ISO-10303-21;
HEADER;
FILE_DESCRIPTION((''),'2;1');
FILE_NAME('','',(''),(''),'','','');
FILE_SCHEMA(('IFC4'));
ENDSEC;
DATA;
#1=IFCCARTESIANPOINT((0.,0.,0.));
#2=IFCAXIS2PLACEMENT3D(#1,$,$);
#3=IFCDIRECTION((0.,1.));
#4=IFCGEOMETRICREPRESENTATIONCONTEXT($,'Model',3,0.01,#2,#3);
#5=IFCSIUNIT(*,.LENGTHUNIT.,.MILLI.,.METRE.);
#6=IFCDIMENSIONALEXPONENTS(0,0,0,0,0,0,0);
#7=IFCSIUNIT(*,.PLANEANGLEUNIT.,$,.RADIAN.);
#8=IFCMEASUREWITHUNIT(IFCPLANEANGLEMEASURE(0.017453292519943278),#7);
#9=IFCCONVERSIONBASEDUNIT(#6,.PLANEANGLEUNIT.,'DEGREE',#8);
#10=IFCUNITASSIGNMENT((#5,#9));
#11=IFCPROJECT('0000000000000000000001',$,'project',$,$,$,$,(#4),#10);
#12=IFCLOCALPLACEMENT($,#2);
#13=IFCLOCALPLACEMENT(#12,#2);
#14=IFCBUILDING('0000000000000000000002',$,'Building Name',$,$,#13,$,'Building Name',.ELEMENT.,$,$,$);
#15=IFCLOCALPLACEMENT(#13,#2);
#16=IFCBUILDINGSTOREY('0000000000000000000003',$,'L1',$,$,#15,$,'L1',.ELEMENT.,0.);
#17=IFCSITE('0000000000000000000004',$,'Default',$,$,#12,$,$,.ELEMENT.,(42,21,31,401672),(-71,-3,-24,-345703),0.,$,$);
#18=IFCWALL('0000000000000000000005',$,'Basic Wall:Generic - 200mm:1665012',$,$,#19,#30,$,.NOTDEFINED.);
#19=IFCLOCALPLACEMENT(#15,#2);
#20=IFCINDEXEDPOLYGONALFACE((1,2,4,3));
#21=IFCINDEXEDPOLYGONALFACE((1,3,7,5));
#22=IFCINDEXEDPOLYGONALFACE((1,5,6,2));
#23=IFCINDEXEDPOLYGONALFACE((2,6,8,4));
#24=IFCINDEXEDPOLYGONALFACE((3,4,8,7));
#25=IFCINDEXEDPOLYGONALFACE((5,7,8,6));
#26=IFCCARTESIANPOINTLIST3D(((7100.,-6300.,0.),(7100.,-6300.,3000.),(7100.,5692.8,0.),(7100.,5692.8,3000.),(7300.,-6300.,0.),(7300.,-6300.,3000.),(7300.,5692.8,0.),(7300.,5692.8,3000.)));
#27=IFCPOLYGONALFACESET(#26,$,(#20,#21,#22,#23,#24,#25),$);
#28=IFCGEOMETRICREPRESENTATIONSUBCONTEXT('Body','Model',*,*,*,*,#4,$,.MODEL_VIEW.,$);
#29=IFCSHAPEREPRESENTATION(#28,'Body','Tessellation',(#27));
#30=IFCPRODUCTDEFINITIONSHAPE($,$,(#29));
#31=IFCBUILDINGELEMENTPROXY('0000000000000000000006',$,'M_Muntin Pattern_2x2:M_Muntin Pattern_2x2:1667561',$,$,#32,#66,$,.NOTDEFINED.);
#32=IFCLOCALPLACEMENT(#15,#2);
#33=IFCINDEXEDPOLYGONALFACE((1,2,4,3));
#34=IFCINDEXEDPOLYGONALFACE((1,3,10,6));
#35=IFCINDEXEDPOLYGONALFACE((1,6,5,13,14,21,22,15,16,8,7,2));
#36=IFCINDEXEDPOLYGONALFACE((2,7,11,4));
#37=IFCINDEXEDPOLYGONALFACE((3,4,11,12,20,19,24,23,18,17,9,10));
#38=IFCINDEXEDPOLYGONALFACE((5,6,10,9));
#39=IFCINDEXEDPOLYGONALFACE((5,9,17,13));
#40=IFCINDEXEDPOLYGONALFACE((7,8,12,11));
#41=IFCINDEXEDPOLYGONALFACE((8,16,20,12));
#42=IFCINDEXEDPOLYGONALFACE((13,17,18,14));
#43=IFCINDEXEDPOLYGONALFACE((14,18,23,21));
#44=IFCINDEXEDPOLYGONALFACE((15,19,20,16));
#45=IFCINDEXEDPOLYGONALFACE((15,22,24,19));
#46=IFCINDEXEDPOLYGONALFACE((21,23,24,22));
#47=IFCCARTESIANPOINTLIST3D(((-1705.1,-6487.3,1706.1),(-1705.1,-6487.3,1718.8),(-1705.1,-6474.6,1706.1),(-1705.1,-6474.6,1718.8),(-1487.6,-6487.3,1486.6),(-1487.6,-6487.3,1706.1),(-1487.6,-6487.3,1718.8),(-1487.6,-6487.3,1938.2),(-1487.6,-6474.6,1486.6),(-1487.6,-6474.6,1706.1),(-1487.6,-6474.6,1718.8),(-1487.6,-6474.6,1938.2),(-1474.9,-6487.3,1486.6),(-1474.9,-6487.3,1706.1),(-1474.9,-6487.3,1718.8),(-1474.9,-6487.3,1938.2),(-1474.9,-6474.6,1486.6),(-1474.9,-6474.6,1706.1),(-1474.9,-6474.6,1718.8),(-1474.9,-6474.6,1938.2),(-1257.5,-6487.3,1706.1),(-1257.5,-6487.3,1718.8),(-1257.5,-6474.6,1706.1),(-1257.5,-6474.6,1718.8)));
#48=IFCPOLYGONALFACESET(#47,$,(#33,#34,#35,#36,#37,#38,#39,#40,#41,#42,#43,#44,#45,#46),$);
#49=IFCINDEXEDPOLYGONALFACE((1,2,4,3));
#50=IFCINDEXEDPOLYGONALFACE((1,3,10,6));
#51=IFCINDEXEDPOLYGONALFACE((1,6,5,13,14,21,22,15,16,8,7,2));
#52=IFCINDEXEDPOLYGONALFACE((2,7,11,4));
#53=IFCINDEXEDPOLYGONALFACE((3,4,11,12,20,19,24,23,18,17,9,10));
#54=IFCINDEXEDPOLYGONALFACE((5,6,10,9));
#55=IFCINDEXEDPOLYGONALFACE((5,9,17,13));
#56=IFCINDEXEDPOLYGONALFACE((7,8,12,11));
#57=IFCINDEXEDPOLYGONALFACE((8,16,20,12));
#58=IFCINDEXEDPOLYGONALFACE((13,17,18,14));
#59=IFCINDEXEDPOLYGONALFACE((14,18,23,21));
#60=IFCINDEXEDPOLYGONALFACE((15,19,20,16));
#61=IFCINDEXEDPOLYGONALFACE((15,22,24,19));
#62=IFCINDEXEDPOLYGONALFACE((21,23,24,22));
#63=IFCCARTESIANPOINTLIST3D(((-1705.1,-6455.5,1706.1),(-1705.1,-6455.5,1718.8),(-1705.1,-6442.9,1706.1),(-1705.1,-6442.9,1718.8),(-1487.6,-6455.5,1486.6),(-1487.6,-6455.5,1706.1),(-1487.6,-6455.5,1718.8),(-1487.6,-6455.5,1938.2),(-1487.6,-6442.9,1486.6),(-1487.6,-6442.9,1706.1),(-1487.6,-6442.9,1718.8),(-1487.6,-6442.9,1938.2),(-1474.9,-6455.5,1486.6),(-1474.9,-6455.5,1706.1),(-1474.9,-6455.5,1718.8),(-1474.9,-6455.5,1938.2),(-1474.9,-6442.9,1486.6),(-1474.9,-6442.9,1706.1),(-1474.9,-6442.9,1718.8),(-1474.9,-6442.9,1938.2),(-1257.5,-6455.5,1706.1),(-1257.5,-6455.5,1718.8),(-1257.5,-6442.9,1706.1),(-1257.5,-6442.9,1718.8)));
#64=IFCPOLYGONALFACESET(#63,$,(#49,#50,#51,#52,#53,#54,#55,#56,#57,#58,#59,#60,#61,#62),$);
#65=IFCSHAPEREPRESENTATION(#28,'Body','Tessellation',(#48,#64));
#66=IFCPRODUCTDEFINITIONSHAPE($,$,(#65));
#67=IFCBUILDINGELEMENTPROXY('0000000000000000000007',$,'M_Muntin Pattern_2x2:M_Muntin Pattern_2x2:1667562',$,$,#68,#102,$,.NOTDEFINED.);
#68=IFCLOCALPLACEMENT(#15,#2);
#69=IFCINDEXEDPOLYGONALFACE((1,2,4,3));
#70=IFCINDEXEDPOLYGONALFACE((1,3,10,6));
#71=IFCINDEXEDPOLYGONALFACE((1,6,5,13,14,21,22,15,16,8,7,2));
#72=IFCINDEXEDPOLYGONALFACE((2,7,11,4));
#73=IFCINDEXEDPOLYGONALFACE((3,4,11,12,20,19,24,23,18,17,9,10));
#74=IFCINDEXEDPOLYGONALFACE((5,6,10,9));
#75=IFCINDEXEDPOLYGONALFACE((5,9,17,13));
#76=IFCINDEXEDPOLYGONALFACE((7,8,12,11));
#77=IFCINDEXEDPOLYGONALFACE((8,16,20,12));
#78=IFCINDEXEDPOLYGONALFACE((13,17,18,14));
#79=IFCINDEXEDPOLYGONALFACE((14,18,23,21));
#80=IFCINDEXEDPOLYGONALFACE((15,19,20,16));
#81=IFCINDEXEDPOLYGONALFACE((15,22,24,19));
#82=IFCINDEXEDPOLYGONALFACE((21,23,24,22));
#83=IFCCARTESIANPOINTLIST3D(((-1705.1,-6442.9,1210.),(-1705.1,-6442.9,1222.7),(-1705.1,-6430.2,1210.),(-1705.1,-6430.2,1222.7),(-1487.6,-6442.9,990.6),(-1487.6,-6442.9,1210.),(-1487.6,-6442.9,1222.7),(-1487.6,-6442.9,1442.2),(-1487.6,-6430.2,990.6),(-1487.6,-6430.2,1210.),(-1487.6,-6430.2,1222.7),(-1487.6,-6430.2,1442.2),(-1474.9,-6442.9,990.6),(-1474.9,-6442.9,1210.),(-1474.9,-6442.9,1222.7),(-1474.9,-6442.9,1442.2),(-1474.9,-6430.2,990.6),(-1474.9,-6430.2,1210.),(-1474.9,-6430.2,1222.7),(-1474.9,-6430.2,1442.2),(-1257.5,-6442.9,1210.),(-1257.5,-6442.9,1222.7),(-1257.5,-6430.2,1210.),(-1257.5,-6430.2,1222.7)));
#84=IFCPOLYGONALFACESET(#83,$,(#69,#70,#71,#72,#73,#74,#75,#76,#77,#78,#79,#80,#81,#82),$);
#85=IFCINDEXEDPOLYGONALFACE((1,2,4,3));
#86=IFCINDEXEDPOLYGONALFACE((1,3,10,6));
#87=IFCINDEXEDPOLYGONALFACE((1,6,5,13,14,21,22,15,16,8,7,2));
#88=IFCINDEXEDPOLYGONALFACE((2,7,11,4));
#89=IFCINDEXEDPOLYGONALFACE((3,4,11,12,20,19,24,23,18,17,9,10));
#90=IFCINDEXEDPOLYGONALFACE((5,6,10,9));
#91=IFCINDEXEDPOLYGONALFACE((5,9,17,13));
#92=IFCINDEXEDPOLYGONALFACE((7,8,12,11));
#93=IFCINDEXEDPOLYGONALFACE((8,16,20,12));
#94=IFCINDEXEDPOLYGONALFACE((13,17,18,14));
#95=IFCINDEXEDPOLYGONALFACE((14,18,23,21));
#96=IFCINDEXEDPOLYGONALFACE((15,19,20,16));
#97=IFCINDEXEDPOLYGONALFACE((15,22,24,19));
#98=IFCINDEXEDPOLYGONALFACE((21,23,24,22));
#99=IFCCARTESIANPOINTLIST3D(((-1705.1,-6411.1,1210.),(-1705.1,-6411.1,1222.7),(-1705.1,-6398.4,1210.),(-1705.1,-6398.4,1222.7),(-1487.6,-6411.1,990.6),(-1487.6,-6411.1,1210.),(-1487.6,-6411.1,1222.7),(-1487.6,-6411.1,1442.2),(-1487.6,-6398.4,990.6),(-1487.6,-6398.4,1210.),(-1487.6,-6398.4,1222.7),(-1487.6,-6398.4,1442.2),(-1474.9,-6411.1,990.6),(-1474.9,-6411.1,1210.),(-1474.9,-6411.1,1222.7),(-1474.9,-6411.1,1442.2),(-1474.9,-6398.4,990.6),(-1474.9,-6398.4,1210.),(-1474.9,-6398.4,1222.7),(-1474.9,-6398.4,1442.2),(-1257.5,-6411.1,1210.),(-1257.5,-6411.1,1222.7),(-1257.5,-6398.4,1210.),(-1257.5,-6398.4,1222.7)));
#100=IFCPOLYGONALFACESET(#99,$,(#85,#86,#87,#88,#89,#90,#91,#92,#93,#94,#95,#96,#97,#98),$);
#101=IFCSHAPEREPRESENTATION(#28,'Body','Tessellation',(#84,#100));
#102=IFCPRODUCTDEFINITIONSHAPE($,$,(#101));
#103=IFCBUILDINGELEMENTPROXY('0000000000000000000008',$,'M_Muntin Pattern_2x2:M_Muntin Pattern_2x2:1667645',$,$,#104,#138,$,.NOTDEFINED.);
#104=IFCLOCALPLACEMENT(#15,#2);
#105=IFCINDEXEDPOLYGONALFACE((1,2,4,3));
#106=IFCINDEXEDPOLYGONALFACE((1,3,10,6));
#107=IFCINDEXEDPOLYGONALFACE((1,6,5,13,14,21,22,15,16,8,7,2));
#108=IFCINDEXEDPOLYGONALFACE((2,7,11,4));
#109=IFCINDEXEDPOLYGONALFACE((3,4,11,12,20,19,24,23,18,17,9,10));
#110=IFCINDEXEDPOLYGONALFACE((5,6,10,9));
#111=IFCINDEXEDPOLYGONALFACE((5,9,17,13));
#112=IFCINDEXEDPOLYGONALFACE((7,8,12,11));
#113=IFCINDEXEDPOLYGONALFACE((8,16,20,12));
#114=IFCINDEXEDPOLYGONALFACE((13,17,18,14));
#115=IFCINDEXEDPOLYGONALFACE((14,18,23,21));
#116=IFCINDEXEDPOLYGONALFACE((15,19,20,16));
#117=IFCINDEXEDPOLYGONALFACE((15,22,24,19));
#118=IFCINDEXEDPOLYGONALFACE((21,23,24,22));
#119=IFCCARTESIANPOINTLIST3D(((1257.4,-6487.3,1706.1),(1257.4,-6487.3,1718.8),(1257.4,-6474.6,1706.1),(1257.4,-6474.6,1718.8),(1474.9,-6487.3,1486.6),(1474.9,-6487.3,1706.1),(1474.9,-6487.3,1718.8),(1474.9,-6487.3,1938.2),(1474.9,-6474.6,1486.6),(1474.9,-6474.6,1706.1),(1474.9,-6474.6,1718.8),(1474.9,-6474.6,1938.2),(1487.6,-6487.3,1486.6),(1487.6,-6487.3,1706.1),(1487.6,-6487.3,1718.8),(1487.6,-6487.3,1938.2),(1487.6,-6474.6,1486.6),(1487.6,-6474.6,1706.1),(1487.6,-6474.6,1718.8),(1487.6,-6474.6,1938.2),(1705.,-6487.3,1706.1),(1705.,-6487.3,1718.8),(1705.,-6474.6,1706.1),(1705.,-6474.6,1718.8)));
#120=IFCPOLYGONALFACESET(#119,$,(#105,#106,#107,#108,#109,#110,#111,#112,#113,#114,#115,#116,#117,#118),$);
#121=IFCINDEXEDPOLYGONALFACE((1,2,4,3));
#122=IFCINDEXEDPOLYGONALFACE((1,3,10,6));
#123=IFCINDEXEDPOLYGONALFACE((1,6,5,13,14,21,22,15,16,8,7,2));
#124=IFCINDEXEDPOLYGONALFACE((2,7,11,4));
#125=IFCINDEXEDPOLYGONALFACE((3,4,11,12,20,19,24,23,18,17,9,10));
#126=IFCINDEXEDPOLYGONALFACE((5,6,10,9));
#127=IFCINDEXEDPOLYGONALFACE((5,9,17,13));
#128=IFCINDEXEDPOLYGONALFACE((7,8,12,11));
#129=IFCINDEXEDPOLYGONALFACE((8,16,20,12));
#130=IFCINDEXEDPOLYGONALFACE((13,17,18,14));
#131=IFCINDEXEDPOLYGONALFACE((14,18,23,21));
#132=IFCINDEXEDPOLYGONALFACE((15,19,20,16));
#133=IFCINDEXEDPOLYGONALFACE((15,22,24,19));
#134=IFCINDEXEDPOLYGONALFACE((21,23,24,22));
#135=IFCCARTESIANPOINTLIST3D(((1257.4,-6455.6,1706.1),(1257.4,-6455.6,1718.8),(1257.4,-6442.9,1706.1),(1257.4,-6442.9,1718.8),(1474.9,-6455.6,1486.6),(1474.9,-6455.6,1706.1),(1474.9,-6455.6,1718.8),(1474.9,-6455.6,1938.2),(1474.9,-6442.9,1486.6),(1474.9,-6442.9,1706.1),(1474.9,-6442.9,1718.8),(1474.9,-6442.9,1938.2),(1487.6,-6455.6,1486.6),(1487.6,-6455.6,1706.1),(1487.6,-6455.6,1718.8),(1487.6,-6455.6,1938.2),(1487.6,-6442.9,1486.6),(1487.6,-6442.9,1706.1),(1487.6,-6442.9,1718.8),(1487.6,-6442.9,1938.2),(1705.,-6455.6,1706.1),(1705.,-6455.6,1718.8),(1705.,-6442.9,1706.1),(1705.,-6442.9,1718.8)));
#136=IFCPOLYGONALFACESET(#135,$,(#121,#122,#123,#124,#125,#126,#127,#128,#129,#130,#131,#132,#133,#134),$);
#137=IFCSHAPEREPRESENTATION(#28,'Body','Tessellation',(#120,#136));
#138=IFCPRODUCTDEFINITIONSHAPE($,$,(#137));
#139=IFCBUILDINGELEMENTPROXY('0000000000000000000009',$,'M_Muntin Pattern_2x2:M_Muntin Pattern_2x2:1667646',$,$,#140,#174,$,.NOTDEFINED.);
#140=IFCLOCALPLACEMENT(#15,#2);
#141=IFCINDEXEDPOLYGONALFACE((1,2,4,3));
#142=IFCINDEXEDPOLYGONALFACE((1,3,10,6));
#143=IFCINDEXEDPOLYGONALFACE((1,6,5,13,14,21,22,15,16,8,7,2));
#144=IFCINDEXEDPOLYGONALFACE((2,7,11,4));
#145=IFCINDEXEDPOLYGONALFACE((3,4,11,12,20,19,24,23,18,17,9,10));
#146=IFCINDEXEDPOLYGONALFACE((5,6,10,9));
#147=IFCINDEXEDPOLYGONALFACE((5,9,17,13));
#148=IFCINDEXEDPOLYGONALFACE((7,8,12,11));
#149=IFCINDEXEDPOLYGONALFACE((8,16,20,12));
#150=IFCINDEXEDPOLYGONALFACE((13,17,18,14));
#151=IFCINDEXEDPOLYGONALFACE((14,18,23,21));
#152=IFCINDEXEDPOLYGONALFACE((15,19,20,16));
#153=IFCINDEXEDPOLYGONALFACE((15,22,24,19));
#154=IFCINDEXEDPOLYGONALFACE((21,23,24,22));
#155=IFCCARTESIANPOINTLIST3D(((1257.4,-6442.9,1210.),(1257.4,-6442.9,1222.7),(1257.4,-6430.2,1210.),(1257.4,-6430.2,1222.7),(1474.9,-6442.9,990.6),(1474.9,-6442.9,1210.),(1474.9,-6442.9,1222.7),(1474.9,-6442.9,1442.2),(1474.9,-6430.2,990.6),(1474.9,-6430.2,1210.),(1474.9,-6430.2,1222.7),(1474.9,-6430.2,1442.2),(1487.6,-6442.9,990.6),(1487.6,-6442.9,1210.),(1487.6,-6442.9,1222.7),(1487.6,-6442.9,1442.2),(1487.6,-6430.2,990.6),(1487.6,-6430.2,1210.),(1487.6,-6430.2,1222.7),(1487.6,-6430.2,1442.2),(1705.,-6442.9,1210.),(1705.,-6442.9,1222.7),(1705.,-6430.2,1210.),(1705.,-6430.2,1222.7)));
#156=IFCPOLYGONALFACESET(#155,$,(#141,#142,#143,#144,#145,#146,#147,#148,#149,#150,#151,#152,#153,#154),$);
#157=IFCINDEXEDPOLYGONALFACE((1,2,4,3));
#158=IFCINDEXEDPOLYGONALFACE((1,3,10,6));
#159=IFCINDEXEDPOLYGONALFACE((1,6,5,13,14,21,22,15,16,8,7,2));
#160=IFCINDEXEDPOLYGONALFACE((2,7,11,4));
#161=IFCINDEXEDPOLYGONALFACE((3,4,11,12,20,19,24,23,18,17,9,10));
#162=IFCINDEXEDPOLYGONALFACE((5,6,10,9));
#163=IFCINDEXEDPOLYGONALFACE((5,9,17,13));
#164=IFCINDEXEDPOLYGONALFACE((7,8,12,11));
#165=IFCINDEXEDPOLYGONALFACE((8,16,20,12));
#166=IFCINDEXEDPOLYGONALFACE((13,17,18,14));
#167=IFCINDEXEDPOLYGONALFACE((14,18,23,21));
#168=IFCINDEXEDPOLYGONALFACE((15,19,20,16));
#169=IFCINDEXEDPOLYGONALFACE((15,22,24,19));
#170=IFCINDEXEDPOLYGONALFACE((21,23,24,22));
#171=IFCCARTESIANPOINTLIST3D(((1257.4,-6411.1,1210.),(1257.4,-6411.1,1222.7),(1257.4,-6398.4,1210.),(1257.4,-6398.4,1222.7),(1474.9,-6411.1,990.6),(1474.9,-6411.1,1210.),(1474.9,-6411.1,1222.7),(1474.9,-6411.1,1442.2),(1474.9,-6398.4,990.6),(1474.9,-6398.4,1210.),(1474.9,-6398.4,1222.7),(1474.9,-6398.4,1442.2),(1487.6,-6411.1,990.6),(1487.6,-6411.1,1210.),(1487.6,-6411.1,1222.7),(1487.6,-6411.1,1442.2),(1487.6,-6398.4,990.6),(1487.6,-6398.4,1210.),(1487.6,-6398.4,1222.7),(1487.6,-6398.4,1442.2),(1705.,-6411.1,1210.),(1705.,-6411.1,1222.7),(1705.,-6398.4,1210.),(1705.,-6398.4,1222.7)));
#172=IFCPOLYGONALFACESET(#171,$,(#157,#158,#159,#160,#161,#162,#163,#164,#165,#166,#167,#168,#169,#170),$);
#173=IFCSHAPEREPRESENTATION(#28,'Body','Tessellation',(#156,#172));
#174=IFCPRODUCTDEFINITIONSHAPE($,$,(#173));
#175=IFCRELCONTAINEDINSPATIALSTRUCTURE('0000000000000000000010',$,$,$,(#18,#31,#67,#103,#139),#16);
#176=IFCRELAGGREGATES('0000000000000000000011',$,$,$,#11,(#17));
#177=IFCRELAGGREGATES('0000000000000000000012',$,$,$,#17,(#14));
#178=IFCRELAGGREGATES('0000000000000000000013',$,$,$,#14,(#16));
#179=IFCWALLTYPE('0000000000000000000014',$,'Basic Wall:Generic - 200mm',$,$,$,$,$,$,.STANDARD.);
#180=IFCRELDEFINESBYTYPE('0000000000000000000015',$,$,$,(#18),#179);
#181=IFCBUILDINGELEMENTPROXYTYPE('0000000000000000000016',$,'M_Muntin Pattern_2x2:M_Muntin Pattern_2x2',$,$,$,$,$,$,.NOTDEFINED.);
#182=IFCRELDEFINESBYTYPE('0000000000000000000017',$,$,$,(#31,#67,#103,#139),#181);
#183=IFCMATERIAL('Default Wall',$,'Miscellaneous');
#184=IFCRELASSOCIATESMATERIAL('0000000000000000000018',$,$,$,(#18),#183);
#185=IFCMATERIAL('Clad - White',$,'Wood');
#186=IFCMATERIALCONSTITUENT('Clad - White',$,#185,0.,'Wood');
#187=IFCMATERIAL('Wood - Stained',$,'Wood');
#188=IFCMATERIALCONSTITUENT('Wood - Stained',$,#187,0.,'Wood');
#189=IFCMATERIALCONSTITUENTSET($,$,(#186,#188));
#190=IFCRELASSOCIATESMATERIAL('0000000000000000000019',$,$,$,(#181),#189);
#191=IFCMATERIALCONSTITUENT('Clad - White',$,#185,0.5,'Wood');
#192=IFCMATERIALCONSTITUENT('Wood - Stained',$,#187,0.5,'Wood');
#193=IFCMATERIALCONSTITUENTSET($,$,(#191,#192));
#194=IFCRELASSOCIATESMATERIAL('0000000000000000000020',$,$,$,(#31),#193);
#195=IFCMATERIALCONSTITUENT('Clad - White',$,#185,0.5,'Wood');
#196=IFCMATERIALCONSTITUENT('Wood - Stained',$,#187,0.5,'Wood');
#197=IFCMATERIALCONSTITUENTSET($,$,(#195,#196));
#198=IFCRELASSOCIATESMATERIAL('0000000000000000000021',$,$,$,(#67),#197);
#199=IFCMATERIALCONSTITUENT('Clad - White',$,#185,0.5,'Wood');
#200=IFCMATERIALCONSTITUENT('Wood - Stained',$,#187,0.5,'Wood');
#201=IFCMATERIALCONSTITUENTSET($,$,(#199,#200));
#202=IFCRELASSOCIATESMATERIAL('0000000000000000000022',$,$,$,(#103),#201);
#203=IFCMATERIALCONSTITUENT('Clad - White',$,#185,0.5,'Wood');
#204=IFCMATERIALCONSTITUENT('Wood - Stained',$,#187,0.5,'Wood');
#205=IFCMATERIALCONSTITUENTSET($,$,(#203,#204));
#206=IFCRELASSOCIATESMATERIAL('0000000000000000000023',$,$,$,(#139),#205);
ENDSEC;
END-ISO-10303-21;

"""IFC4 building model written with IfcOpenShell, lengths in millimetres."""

from ifc_helpers import new_model, entity, si_unit, converted_unit, direction, frame, origin, place, context, subcontext, project, spatial, indexed_curve, outline, extrude, source, transform, mapped, material, constituent, constituent_set, type_object, type_shapes, element, save


model = new_model("IFC4")

# Units and contexts
model_context = context("Model", 3, precision=0.01, world=origin(), true_north=direction((0.0, 1.0)))
body_context = subcontext(model_context, "Body", "Model", "MODEL_VIEW")
ifc_project = project(units=[si_unit("LENGTHUNIT", "METRE", prefix="MILLI"), converted_unit("PLANEANGLEUNIT", "DEGREE", entity("IfcPlaneAngleMeasure", 0.017453292519943278), si_unit("PLANEANGLEUNIT", "RADIAN"), dimensions=[0, 0, 0, 0, 0, 0, 0])], contexts=[model_context])

# Site, building, storey
site_placement = place(None, origin())
site = spatial("IfcSite", under=ifc_project, at=site_placement, Name="Default", CompositionType="ELEMENT", RefLatitude=(42, 21, 31, 401672), RefLongitude=(-71, -3, -24, -345703), RefElevation=0.0)
building_placement = place(site_placement, origin())
building = spatial("IfcBuilding", under=site, at=building_placement, Name="Building Name", LongName="Building Name", CompositionType="ELEMENT")
storey_placement = place(building_placement, origin())
storey = spatial("IfcBuildingStorey", under=building, at=storey_placement, Name="L1", LongName="L1", CompositionType="ELEMENT", Elevation=0.0)

# Wall
ifc_material_1 = material(Name="Default Wall", Category="Miscellaneous")
wall_type = type_object("IfcWallType", Name="Basic Wall:Generic - 200mm", PredefinedType="STANDARD")
wall_placement = place(storey_placement, frame((7200.0, -6300.0, 0.0), z_axis=(0.0, 0.0, 1.0), x_axis=(0.0, 1.0, 0.0)))
element("IfcWall", 1, at=wall_placement, inside=storey, type_object=wall_type, material=ifc_material_1, Name="Basic Wall:Generic - 200mm:1665012", PredefinedType="NOTDEFINED", context=body_context, shape_type="SweptSolid", body=[
    extrude(outline(indexed_curve([(11992.8, 100.0), (0.0, 100.0), (0.0, -100.0), (11992.8, -100.0), (11992.8, 100.0)], self_intersect=False)), origin(), (0.0, 0.0, 1.0), 3000.0),
])

# Building element proxies
ifc_material_2 = material(Name="Clad - White", Category="Wood")
ifc_constituent_1 = constituent(ifc_material_2, Name="Clad - White", Category="Wood", fraction=0.5)
ifc_material_3 = material(Name="Wood - Stained", Category="Wood")
ifc_constituent_2 = constituent(ifc_material_3, Name="Wood - Stained", Category="Wood", fraction=0.5)
ifc_constituent_set_1 = constituent_set(constituents=[ifc_constituent_1, ifc_constituent_2])
ifc_constituent_3 = constituent(ifc_material_2, Name="Clad - White", Category="Wood", fraction=0.0)
ifc_constituent_4 = constituent(ifc_material_3, Name="Wood - Stained", Category="Wood", fraction=0.0)
ifc_constituent_set_2 = constituent_set(constituents=[ifc_constituent_3, ifc_constituent_4])
building_element_proxy_type_1 = type_object("IfcBuildingElementProxyType", Name="M_Muntin Pattern_2x2:M_Muntin Pattern_2x2", PredefinedType="NOTDEFINED", material=ifc_constituent_set_2)
shared_shape_1 = source(origin(), body_context, "Body", "SweptSolid", [
    extrude(outline(indexed_curve([(6.4, -6.4), (225.8, -6.4), (225.8, 6.3), (6.4, 6.3), (6.4, 223.8), (-6.3, 223.8), (-6.3, 6.3), (-225.8, 6.3), (-225.8, -6.4), (-6.3, -6.4), (-6.3, -223.8), (6.4, -223.8), (6.4, -6.4)], self_intersect=False)), frame((0.0, 9.5, 225.8), z_axis=(0.0, 1.0, 0.0), x_axis=(0.0, 0.0, 1.0)), (0.0, 0.0, 1.0), 12.7),
    extrude(outline(indexed_curve([(6.4, -6.4), (225.8, -6.4), (225.8, 6.3), (6.4, 6.3), (6.4, 223.8), (-6.3, 223.8), (-6.3, 6.3), (-225.8, 6.3), (-225.8, -6.4), (-6.3, -6.4), (-6.3, -223.8), (6.4, -223.8), (6.4, -6.4)], self_intersect=False)), frame((0.0, -22.2, 225.8), z_axis=(0.0, 1.0, 0.0), x_axis=(0.0, 0.0, 1.0)), (0.0, 0.0, 1.0), 12.7),
])
type_shapes(building_element_proxy_type_1, [shared_shape_1])
proxy_1_placement = place(storey_placement, frame((-1481.2, -6465.1, 1486.6), z_axis=(0.0, 0.0, 1.0), x_axis=(-1.0, 0.0, 0.0)))
element("IfcBuildingElementProxy", 2, at=proxy_1_placement, inside=storey, type_object=building_element_proxy_type_1, material=ifc_constituent_set_1, Name="M_Muntin Pattern_2x2:M_Muntin Pattern_2x2:1667561", PredefinedType="NOTDEFINED", context=body_context, shape_type="MappedRepresentation", body=[
    mapped(shared_shape_1, transform((0.0, 0.0, 0.0), scale=1.0)),
])
ifc_constituent_5 = constituent(ifc_material_2, Name="Clad - White", Category="Wood", fraction=0.5)
ifc_constituent_6 = constituent(ifc_material_3, Name="Wood - Stained", Category="Wood", fraction=0.5)
ifc_constituent_set_3 = constituent_set(constituents=[ifc_constituent_5, ifc_constituent_6])
proxy_2_placement = place(storey_placement, frame((-1481.2, -6420.6, 990.6), z_axis=(0.0, 0.0, 1.0), x_axis=(-1.0, 0.0, 0.0)))
element("IfcBuildingElementProxy", 3, at=proxy_2_placement, inside=storey, type_object=building_element_proxy_type_1, material=ifc_constituent_set_3, Name="M_Muntin Pattern_2x2:M_Muntin Pattern_2x2:1667562", PredefinedType="NOTDEFINED", context=body_context, shape_type="MappedRepresentation", body=[
    mapped(shared_shape_1, transform((0.0, 0.0, 0.0), scale=1.0)),
])
ifc_constituent_7 = constituent(ifc_material_2, Name="Clad - White", Category="Wood", fraction=0.5)
ifc_constituent_8 = constituent(ifc_material_3, Name="Wood - Stained", Category="Wood", fraction=0.5)
ifc_constituent_set_4 = constituent_set(constituents=[ifc_constituent_7, ifc_constituent_8])
proxy_3_placement = place(storey_placement, frame((1481.3, -6465.1, 1486.6), z_axis=(0.0, 0.0, 1.0), x_axis=(-1.0, 0.0, 0.0)))
element("IfcBuildingElementProxy", 4, at=proxy_3_placement, inside=storey, type_object=building_element_proxy_type_1, material=ifc_constituent_set_4, Name="M_Muntin Pattern_2x2:M_Muntin Pattern_2x2:1667645", PredefinedType="NOTDEFINED", context=body_context, shape_type="MappedRepresentation", body=[
    mapped(shared_shape_1, transform((0.0, 0.0, 0.0), scale=1.0)),
])
ifc_constituent_9 = constituent(ifc_material_2, Name="Clad - White", Category="Wood", fraction=0.5)
ifc_constituent_10 = constituent(ifc_material_3, Name="Wood - Stained", Category="Wood", fraction=0.5)
ifc_constituent_set_5 = constituent_set(constituents=[ifc_constituent_9, ifc_constituent_10])
proxy_4_placement = place(storey_placement, frame((1481.3, -6420.6, 990.6), z_axis=(0.0, 0.0, 1.0), x_axis=(-1.0, 0.0, 0.0)))
element("IfcBuildingElementProxy", 5, at=proxy_4_placement, inside=storey, type_object=building_element_proxy_type_1, material=ifc_constituent_set_5, Name="M_Muntin Pattern_2x2:M_Muntin Pattern_2x2:1667646", PredefinedType="NOTDEFINED", context=body_context, shape_type="MappedRepresentation", body=[
    mapped(shared_shape_1, transform((0.0, 0.0, 0.0), scale=1.0)),
])

save(model, "model.ifc")
